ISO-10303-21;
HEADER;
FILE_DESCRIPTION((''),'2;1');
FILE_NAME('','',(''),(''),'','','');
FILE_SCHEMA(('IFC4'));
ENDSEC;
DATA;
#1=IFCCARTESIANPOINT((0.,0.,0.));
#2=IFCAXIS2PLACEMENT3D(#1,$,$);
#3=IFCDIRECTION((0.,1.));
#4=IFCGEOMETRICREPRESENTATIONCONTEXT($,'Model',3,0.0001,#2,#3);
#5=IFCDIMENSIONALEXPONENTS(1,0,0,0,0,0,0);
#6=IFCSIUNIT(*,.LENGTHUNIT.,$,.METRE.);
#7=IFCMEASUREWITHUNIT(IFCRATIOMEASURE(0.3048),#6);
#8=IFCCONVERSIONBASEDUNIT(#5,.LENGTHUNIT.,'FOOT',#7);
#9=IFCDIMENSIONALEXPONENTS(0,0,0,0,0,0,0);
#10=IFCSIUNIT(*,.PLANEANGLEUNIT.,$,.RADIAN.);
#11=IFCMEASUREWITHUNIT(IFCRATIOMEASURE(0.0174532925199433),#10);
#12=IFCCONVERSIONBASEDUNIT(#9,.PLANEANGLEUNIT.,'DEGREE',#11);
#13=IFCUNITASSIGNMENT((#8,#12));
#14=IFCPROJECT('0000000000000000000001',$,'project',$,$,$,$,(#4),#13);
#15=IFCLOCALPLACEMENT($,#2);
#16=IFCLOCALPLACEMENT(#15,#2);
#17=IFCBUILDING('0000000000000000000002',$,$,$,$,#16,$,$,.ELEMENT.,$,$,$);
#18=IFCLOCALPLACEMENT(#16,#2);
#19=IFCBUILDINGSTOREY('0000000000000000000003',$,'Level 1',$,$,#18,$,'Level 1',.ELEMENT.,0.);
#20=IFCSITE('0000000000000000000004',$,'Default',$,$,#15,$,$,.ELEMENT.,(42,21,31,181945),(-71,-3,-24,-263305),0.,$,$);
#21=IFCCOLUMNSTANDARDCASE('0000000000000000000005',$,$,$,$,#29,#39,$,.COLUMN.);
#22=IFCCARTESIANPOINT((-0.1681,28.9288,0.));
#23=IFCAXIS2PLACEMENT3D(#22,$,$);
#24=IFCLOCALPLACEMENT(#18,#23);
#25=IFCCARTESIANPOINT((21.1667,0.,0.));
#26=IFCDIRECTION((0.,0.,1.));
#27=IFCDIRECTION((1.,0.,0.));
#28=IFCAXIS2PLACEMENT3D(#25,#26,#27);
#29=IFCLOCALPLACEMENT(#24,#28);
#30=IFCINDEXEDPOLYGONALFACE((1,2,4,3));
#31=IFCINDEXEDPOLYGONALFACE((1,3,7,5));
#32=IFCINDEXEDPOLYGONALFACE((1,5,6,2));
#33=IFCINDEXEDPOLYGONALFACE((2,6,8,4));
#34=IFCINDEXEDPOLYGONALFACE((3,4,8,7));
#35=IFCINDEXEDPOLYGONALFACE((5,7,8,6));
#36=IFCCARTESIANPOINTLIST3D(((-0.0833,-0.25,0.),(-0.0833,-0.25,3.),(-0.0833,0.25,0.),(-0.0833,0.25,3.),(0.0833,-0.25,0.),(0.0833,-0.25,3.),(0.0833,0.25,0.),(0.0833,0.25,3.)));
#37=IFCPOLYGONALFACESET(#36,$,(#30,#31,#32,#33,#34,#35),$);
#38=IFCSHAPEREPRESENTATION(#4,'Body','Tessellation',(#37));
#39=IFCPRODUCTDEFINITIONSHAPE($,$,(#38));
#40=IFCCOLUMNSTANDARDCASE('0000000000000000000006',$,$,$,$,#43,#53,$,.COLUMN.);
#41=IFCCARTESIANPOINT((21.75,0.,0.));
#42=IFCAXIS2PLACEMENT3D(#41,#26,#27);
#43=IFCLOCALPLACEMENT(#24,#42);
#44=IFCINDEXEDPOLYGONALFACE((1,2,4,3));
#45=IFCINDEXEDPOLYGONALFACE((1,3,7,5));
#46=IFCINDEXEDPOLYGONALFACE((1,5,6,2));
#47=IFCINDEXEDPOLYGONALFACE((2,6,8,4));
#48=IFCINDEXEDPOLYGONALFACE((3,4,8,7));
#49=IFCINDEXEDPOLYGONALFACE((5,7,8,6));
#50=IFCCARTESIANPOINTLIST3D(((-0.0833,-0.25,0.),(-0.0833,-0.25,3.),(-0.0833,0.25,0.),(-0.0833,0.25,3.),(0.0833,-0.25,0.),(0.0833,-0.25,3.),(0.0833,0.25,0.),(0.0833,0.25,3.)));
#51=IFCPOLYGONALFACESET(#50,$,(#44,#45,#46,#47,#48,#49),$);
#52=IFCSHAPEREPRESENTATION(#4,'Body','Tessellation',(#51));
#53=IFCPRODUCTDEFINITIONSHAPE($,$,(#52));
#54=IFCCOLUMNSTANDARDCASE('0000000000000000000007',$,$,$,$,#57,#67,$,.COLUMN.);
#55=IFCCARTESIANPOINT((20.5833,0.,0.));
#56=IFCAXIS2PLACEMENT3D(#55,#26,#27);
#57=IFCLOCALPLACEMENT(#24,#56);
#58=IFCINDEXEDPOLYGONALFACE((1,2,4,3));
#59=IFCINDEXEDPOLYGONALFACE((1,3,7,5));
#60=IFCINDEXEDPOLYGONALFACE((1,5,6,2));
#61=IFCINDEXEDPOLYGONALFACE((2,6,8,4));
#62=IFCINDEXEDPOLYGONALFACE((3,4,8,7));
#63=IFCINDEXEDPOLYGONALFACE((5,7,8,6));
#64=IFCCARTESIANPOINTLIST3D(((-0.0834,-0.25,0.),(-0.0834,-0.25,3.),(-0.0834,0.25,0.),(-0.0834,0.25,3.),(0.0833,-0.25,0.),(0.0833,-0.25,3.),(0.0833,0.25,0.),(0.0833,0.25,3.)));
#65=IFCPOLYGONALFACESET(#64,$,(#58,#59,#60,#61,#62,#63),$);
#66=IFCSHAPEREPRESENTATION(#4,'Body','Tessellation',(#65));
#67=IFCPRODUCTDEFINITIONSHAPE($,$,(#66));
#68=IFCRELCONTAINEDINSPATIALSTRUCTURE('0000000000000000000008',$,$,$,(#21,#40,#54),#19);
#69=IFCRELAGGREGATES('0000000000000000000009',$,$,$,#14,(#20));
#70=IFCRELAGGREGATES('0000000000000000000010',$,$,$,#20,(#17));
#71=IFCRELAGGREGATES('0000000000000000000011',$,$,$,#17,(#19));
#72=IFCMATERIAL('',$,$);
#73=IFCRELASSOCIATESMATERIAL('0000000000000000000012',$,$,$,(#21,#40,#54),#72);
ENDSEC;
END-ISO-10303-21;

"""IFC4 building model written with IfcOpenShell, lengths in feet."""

from ifc_helpers import new_model, entity, si_unit, converted_unit, direction, frame, origin, place, context, project, spatial, rectangle, extrude, material, element, save


model = new_model("IFC4")

# Units and contexts
model_context = context("Model", 3, precision=0.0001, world=origin(), true_north=direction((0.0, 1.0)))
ifc_project = project(units=[converted_unit("LENGTHUNIT", "FOOT", entity("IfcRatioMeasure", 0.3048), si_unit("LENGTHUNIT", "METRE"), dimensions=[1, 0, 0, 0, 0, 0, 0]), converted_unit("PLANEANGLEUNIT", "DEGREE", entity("IfcRatioMeasure", 0.0174532925199433), si_unit("PLANEANGLEUNIT", "RADIAN"), dimensions=[0, 0, 0, 0, 0, 0, 0])], contexts=[model_context])

# Site, building, storey
site_placement = place(None, origin())
site = spatial("IfcSite", under=ifc_project, at=site_placement, Name="Default", CompositionType="ELEMENT", RefLatitude=(42, 21, 31, 181945), RefLongitude=(-71, -3, -24, -263305), RefElevation=0.0)
building_placement = place(site_placement, origin())
building = spatial("IfcBuilding", under=site, at=building_placement, CompositionType="ELEMENT")
storey_placement = place(building_placement, origin())
storey = spatial("IfcBuildingStorey", under=building, at=storey_placement, Name="Level 1", LongName="Level 1", CompositionType="ELEMENT", Elevation=0.0)

# Columns
ifc_material = material(Name="")
placement = place(storey_placement, frame((-0.1681, 28.9288, 0.0)))
for number, where, z_axis, x_axis in (
    (1, (21.1667, 0.0, 0.0), (0.0, 0.0, 1.0), (1.0, 0.0, 0.0)),
    (2, (21.75, 0.0, 0.0), (0.0, 0.0, 1.0), (1.0, 0.0, 0.0)),
    (3, (20.5833, 0.0, 0.0), (0.0, 0.0, 1.0), (1.0, 0.0, 0.0)),
):
    element("IfcColumnStandardCase", number, at=place(placement, frame(where, z_axis=z_axis, x_axis=x_axis)), inside=storey, material=ifc_material, PredefinedType="COLUMN", context=model_context, shape_type="SweptSolid", body=[
        extrude(rectangle(XDim=0.1667, YDim=0.5), origin(), (0.0, 0.0, 1.0), 3.0),
    ])

save(model, "model.ifc")
